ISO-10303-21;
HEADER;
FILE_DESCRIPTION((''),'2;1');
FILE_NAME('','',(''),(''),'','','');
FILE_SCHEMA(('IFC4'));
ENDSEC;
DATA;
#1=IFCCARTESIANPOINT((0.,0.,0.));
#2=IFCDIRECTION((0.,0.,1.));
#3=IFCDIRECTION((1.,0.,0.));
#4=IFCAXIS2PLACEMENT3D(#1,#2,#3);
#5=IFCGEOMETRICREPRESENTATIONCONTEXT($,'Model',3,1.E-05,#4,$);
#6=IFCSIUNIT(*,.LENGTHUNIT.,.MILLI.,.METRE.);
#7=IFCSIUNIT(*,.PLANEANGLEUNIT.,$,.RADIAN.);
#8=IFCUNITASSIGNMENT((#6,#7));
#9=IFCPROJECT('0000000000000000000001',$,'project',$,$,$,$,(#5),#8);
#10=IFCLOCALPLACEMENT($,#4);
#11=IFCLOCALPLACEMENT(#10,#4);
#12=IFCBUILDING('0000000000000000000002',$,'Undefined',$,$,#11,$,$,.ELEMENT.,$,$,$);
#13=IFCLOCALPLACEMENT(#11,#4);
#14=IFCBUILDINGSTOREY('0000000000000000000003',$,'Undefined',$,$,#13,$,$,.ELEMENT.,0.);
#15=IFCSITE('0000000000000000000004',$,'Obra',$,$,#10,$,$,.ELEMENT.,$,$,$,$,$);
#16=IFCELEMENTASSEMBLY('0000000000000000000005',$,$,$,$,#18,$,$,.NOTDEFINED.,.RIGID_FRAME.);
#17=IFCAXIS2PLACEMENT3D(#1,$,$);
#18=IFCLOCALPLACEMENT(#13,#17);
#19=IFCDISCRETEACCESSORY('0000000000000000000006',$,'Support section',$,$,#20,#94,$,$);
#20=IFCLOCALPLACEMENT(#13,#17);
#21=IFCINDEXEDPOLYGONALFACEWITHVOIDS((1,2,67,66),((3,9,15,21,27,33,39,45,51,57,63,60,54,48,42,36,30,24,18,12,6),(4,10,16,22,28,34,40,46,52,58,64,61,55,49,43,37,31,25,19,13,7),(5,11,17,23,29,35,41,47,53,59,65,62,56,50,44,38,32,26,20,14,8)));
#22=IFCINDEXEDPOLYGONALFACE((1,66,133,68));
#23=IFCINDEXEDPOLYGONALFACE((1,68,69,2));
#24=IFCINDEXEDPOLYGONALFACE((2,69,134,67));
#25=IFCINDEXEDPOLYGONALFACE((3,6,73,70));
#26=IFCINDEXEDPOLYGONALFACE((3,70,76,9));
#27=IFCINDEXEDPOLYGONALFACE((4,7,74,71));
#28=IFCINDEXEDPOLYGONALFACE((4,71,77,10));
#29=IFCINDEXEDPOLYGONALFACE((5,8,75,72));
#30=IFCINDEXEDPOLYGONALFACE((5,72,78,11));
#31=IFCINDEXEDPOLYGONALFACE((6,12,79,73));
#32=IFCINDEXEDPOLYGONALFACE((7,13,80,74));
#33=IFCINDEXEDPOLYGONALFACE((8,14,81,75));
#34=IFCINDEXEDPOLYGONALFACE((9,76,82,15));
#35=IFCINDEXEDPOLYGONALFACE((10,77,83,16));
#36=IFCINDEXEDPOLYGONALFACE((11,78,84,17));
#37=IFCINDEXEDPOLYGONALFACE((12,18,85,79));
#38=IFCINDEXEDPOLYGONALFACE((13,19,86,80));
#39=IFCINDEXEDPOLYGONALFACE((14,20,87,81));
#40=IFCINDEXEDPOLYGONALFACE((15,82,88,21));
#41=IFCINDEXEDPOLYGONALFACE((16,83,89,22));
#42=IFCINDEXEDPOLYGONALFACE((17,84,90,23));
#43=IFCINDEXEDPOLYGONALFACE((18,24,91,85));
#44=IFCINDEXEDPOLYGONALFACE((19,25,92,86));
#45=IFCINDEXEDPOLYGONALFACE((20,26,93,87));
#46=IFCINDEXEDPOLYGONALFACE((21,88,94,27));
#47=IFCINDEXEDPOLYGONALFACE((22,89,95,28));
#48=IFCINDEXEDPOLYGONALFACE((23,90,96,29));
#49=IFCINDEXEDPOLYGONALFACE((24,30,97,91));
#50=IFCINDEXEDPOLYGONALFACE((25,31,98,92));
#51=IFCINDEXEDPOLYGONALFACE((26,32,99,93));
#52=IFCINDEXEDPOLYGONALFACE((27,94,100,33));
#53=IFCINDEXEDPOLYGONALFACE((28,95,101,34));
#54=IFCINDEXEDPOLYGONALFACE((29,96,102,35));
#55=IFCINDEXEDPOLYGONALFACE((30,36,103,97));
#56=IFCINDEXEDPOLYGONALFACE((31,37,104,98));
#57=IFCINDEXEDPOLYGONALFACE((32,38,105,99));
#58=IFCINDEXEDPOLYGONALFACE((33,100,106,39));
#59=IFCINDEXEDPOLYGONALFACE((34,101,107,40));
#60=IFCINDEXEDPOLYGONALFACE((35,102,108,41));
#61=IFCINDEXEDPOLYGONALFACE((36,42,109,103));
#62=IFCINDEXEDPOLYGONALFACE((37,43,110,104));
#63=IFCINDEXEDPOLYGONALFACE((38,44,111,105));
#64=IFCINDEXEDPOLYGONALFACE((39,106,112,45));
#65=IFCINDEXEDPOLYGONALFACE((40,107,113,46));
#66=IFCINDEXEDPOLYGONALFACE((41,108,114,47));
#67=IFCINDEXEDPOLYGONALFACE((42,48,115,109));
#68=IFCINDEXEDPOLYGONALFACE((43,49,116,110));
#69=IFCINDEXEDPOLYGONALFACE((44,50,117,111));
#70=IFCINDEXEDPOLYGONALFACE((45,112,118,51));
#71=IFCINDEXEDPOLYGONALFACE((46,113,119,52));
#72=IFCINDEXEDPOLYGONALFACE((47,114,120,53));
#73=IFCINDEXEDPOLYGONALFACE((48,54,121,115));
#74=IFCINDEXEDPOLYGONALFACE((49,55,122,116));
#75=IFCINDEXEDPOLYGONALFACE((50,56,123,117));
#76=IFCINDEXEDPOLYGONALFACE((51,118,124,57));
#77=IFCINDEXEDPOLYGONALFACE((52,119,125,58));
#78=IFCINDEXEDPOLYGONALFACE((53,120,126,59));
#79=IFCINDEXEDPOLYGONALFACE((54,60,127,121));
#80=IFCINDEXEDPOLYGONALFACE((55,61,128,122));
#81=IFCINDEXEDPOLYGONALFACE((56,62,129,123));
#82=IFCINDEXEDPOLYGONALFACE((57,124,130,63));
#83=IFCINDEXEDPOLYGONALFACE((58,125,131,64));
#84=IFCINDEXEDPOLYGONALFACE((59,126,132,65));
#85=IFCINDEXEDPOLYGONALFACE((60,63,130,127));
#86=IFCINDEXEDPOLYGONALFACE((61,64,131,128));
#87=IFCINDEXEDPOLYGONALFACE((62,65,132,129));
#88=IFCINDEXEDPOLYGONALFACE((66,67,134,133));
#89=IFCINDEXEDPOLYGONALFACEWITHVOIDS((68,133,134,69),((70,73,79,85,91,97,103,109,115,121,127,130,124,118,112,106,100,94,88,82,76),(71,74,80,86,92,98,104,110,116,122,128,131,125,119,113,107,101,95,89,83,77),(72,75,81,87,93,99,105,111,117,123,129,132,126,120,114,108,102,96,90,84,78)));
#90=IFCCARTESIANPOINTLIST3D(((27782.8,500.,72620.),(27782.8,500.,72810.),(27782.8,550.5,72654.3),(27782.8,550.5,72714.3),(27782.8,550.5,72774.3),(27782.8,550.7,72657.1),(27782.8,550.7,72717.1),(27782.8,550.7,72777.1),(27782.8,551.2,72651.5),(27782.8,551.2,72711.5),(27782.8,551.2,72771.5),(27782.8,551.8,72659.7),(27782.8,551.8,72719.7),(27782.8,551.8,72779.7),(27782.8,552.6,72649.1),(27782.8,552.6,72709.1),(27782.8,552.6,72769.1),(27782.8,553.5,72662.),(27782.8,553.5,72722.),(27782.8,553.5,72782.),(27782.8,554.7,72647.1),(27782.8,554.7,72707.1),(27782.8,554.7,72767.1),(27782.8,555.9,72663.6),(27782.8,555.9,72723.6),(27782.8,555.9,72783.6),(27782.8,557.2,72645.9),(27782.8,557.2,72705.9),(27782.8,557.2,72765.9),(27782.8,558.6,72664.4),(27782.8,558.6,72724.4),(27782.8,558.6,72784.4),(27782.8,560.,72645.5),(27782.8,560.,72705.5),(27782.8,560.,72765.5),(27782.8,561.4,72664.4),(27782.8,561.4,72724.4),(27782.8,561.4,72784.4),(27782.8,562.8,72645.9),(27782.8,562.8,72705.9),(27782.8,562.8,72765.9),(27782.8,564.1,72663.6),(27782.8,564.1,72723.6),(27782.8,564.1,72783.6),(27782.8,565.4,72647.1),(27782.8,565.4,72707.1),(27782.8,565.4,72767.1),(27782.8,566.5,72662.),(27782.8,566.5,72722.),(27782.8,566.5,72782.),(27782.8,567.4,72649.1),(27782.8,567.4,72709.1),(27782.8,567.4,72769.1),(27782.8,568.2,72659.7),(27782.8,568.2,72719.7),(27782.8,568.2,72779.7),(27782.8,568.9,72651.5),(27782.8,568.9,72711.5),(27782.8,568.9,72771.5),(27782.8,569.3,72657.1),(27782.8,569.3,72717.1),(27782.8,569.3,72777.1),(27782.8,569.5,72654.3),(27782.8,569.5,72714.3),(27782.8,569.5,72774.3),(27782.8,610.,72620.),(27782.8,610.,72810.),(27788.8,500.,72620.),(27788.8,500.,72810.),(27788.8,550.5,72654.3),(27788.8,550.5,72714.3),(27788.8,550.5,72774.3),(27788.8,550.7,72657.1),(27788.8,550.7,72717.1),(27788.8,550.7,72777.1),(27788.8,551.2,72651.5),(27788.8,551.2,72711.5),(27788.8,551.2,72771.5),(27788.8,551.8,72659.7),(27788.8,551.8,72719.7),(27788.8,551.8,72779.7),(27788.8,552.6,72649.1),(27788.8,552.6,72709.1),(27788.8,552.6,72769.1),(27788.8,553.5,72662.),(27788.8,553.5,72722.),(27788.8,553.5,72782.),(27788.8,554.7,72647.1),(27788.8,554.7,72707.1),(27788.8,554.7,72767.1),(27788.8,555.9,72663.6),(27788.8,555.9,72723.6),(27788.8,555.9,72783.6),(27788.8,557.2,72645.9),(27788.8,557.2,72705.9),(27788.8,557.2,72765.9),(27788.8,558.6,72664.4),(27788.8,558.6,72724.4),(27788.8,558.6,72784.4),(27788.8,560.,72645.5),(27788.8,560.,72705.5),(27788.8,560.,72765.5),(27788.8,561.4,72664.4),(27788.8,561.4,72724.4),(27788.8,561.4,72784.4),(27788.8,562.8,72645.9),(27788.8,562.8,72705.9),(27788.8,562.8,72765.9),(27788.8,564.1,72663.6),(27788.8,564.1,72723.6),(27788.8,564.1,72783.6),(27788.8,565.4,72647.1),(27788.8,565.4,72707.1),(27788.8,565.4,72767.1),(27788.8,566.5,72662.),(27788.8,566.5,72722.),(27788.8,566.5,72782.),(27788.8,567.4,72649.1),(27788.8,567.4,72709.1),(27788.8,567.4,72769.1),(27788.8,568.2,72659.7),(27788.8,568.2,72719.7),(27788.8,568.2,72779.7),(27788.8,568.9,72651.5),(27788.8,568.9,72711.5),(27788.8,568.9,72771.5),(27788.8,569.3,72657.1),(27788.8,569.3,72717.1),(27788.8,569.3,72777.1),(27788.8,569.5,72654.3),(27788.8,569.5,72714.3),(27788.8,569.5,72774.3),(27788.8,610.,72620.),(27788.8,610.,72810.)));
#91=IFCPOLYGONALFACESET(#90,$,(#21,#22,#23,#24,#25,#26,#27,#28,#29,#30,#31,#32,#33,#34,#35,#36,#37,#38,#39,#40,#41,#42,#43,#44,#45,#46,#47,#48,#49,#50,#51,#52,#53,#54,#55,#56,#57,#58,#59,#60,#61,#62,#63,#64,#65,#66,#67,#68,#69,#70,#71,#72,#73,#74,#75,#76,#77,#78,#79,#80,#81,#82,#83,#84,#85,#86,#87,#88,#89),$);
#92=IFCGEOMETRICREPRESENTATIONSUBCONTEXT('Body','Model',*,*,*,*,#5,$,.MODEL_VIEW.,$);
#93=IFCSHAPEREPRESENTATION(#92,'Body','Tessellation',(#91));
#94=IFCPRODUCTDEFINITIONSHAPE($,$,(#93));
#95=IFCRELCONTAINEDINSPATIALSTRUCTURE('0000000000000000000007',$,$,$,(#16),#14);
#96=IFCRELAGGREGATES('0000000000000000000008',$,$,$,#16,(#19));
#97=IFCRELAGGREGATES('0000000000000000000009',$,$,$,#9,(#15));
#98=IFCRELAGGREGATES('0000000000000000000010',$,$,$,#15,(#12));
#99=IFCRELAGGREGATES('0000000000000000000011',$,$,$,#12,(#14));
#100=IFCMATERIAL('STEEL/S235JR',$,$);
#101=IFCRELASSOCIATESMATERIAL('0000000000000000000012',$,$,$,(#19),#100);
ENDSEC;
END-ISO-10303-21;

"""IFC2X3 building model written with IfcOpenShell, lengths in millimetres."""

from ifc_helpers import new_model, si_unit, frame, origin_with_axes, origin_2d_with_axis, place, context, subcontext, project, spatial, rectangle, circle, extrude, source, transform, mapped, material, element, aggregate, save


model = new_model("IFC2X3")

# Units and contexts
model_context = context("Model", 3, precision=1e-05, world=origin_with_axes())
body_context = subcontext(model_context, "Body", "Model", "MODEL_VIEW")
ifc_project = project(units=[si_unit("LENGTHUNIT", "METRE", prefix="MILLI"), si_unit("PLANEANGLEUNIT", "RADIAN")], contexts=[model_context])

# Site, building, storey
site_placement = place(None, origin_with_axes())
site = spatial("IfcSite", under=ifc_project, at=site_placement, Name="Obra", CompositionType="ELEMENT")
building_placement = place(site_placement, origin_with_axes())
building = spatial("IfcBuilding", under=site, at=building_placement, Name="Undefined", CompositionType="ELEMENT")
storey_placement = place(building_placement, origin_with_axes())
storey = spatial("IfcBuildingStorey", under=building, at=storey_placement, Name="Undefined", CompositionType="ELEMENT", Elevation=0.0)

# Shared definitions
ifc_material_1 = material(Name="STEEL/S235JR")

# Shared definitions
shared_shape_1 = source(origin_with_axes(), body_context, "Body", "SweptSolid", [
    extrude(circle(Radius=9.5, at=origin_2d_with_axis()), frame((0.0, -9.2, 0.0), z_axis=(0.0, 1.0, 0.0), x_axis=(1.0, 0.0, 0.0)), (0.0, 0.0, 1.0), 6.2),
])

# Element assembly, discrete accessory, opening
assembly_1_placement = place(storey_placement, origin_with_axes())
assembly_1 = element("IfcElementAssembly", 1, at=assembly_1_placement, inside=storey, AssemblyPlace="NOTDEFINED", PredefinedType="RIGID_FRAME")
discrete_accessory_1_placement = place(assembly_1_placement, frame((27785.8, 555.0, 72620.0), z_axis=(0.0, 0.0, 1.0), x_axis=(0.000002, -1.0, 0.0)))
discrete_accessory_1 = element("IfcDiscreteAccessory", 2, at=discrete_accessory_1_placement, material=ifc_material_1, Name="Support section", context=body_context, shape_type="SweptSolid", body=[
    extrude(rectangle(XDim=6.0, YDim=110.0, at=origin_2d_with_axis()), frame((0.0, 0.0, 190.0), z_axis=(0.0, 0.0, -1.0), x_axis=(0.0, 1.0, 0.0)), (0.0, 0.0, 1.0), 190.0),
])
opening_1_placement = place(assembly_1_placement, frame((27779.7, 510.0, 72835.0), z_axis=(-0.000002, 1.0, 0.0), x_axis=(0.0, 0.0, -1.0)))
element("IfcOpeningElement", 3, at=opening_1_placement, cuts=discrete_accessory_1, ObjectType="Opening", context=body_context, shape_type="MappedRepresentation", body=[
    mapped(shared_shape_1, transform((60.0, 0.0, 50.0))),
    mapped(shared_shape_1, transform((120.0, 0.0, 50.0))),
    mapped(shared_shape_1, transform((180.0, 0.0, 50.0))),
])
aggregate(assembly_1, [discrete_accessory_1])

save(model, "model.ifc")
